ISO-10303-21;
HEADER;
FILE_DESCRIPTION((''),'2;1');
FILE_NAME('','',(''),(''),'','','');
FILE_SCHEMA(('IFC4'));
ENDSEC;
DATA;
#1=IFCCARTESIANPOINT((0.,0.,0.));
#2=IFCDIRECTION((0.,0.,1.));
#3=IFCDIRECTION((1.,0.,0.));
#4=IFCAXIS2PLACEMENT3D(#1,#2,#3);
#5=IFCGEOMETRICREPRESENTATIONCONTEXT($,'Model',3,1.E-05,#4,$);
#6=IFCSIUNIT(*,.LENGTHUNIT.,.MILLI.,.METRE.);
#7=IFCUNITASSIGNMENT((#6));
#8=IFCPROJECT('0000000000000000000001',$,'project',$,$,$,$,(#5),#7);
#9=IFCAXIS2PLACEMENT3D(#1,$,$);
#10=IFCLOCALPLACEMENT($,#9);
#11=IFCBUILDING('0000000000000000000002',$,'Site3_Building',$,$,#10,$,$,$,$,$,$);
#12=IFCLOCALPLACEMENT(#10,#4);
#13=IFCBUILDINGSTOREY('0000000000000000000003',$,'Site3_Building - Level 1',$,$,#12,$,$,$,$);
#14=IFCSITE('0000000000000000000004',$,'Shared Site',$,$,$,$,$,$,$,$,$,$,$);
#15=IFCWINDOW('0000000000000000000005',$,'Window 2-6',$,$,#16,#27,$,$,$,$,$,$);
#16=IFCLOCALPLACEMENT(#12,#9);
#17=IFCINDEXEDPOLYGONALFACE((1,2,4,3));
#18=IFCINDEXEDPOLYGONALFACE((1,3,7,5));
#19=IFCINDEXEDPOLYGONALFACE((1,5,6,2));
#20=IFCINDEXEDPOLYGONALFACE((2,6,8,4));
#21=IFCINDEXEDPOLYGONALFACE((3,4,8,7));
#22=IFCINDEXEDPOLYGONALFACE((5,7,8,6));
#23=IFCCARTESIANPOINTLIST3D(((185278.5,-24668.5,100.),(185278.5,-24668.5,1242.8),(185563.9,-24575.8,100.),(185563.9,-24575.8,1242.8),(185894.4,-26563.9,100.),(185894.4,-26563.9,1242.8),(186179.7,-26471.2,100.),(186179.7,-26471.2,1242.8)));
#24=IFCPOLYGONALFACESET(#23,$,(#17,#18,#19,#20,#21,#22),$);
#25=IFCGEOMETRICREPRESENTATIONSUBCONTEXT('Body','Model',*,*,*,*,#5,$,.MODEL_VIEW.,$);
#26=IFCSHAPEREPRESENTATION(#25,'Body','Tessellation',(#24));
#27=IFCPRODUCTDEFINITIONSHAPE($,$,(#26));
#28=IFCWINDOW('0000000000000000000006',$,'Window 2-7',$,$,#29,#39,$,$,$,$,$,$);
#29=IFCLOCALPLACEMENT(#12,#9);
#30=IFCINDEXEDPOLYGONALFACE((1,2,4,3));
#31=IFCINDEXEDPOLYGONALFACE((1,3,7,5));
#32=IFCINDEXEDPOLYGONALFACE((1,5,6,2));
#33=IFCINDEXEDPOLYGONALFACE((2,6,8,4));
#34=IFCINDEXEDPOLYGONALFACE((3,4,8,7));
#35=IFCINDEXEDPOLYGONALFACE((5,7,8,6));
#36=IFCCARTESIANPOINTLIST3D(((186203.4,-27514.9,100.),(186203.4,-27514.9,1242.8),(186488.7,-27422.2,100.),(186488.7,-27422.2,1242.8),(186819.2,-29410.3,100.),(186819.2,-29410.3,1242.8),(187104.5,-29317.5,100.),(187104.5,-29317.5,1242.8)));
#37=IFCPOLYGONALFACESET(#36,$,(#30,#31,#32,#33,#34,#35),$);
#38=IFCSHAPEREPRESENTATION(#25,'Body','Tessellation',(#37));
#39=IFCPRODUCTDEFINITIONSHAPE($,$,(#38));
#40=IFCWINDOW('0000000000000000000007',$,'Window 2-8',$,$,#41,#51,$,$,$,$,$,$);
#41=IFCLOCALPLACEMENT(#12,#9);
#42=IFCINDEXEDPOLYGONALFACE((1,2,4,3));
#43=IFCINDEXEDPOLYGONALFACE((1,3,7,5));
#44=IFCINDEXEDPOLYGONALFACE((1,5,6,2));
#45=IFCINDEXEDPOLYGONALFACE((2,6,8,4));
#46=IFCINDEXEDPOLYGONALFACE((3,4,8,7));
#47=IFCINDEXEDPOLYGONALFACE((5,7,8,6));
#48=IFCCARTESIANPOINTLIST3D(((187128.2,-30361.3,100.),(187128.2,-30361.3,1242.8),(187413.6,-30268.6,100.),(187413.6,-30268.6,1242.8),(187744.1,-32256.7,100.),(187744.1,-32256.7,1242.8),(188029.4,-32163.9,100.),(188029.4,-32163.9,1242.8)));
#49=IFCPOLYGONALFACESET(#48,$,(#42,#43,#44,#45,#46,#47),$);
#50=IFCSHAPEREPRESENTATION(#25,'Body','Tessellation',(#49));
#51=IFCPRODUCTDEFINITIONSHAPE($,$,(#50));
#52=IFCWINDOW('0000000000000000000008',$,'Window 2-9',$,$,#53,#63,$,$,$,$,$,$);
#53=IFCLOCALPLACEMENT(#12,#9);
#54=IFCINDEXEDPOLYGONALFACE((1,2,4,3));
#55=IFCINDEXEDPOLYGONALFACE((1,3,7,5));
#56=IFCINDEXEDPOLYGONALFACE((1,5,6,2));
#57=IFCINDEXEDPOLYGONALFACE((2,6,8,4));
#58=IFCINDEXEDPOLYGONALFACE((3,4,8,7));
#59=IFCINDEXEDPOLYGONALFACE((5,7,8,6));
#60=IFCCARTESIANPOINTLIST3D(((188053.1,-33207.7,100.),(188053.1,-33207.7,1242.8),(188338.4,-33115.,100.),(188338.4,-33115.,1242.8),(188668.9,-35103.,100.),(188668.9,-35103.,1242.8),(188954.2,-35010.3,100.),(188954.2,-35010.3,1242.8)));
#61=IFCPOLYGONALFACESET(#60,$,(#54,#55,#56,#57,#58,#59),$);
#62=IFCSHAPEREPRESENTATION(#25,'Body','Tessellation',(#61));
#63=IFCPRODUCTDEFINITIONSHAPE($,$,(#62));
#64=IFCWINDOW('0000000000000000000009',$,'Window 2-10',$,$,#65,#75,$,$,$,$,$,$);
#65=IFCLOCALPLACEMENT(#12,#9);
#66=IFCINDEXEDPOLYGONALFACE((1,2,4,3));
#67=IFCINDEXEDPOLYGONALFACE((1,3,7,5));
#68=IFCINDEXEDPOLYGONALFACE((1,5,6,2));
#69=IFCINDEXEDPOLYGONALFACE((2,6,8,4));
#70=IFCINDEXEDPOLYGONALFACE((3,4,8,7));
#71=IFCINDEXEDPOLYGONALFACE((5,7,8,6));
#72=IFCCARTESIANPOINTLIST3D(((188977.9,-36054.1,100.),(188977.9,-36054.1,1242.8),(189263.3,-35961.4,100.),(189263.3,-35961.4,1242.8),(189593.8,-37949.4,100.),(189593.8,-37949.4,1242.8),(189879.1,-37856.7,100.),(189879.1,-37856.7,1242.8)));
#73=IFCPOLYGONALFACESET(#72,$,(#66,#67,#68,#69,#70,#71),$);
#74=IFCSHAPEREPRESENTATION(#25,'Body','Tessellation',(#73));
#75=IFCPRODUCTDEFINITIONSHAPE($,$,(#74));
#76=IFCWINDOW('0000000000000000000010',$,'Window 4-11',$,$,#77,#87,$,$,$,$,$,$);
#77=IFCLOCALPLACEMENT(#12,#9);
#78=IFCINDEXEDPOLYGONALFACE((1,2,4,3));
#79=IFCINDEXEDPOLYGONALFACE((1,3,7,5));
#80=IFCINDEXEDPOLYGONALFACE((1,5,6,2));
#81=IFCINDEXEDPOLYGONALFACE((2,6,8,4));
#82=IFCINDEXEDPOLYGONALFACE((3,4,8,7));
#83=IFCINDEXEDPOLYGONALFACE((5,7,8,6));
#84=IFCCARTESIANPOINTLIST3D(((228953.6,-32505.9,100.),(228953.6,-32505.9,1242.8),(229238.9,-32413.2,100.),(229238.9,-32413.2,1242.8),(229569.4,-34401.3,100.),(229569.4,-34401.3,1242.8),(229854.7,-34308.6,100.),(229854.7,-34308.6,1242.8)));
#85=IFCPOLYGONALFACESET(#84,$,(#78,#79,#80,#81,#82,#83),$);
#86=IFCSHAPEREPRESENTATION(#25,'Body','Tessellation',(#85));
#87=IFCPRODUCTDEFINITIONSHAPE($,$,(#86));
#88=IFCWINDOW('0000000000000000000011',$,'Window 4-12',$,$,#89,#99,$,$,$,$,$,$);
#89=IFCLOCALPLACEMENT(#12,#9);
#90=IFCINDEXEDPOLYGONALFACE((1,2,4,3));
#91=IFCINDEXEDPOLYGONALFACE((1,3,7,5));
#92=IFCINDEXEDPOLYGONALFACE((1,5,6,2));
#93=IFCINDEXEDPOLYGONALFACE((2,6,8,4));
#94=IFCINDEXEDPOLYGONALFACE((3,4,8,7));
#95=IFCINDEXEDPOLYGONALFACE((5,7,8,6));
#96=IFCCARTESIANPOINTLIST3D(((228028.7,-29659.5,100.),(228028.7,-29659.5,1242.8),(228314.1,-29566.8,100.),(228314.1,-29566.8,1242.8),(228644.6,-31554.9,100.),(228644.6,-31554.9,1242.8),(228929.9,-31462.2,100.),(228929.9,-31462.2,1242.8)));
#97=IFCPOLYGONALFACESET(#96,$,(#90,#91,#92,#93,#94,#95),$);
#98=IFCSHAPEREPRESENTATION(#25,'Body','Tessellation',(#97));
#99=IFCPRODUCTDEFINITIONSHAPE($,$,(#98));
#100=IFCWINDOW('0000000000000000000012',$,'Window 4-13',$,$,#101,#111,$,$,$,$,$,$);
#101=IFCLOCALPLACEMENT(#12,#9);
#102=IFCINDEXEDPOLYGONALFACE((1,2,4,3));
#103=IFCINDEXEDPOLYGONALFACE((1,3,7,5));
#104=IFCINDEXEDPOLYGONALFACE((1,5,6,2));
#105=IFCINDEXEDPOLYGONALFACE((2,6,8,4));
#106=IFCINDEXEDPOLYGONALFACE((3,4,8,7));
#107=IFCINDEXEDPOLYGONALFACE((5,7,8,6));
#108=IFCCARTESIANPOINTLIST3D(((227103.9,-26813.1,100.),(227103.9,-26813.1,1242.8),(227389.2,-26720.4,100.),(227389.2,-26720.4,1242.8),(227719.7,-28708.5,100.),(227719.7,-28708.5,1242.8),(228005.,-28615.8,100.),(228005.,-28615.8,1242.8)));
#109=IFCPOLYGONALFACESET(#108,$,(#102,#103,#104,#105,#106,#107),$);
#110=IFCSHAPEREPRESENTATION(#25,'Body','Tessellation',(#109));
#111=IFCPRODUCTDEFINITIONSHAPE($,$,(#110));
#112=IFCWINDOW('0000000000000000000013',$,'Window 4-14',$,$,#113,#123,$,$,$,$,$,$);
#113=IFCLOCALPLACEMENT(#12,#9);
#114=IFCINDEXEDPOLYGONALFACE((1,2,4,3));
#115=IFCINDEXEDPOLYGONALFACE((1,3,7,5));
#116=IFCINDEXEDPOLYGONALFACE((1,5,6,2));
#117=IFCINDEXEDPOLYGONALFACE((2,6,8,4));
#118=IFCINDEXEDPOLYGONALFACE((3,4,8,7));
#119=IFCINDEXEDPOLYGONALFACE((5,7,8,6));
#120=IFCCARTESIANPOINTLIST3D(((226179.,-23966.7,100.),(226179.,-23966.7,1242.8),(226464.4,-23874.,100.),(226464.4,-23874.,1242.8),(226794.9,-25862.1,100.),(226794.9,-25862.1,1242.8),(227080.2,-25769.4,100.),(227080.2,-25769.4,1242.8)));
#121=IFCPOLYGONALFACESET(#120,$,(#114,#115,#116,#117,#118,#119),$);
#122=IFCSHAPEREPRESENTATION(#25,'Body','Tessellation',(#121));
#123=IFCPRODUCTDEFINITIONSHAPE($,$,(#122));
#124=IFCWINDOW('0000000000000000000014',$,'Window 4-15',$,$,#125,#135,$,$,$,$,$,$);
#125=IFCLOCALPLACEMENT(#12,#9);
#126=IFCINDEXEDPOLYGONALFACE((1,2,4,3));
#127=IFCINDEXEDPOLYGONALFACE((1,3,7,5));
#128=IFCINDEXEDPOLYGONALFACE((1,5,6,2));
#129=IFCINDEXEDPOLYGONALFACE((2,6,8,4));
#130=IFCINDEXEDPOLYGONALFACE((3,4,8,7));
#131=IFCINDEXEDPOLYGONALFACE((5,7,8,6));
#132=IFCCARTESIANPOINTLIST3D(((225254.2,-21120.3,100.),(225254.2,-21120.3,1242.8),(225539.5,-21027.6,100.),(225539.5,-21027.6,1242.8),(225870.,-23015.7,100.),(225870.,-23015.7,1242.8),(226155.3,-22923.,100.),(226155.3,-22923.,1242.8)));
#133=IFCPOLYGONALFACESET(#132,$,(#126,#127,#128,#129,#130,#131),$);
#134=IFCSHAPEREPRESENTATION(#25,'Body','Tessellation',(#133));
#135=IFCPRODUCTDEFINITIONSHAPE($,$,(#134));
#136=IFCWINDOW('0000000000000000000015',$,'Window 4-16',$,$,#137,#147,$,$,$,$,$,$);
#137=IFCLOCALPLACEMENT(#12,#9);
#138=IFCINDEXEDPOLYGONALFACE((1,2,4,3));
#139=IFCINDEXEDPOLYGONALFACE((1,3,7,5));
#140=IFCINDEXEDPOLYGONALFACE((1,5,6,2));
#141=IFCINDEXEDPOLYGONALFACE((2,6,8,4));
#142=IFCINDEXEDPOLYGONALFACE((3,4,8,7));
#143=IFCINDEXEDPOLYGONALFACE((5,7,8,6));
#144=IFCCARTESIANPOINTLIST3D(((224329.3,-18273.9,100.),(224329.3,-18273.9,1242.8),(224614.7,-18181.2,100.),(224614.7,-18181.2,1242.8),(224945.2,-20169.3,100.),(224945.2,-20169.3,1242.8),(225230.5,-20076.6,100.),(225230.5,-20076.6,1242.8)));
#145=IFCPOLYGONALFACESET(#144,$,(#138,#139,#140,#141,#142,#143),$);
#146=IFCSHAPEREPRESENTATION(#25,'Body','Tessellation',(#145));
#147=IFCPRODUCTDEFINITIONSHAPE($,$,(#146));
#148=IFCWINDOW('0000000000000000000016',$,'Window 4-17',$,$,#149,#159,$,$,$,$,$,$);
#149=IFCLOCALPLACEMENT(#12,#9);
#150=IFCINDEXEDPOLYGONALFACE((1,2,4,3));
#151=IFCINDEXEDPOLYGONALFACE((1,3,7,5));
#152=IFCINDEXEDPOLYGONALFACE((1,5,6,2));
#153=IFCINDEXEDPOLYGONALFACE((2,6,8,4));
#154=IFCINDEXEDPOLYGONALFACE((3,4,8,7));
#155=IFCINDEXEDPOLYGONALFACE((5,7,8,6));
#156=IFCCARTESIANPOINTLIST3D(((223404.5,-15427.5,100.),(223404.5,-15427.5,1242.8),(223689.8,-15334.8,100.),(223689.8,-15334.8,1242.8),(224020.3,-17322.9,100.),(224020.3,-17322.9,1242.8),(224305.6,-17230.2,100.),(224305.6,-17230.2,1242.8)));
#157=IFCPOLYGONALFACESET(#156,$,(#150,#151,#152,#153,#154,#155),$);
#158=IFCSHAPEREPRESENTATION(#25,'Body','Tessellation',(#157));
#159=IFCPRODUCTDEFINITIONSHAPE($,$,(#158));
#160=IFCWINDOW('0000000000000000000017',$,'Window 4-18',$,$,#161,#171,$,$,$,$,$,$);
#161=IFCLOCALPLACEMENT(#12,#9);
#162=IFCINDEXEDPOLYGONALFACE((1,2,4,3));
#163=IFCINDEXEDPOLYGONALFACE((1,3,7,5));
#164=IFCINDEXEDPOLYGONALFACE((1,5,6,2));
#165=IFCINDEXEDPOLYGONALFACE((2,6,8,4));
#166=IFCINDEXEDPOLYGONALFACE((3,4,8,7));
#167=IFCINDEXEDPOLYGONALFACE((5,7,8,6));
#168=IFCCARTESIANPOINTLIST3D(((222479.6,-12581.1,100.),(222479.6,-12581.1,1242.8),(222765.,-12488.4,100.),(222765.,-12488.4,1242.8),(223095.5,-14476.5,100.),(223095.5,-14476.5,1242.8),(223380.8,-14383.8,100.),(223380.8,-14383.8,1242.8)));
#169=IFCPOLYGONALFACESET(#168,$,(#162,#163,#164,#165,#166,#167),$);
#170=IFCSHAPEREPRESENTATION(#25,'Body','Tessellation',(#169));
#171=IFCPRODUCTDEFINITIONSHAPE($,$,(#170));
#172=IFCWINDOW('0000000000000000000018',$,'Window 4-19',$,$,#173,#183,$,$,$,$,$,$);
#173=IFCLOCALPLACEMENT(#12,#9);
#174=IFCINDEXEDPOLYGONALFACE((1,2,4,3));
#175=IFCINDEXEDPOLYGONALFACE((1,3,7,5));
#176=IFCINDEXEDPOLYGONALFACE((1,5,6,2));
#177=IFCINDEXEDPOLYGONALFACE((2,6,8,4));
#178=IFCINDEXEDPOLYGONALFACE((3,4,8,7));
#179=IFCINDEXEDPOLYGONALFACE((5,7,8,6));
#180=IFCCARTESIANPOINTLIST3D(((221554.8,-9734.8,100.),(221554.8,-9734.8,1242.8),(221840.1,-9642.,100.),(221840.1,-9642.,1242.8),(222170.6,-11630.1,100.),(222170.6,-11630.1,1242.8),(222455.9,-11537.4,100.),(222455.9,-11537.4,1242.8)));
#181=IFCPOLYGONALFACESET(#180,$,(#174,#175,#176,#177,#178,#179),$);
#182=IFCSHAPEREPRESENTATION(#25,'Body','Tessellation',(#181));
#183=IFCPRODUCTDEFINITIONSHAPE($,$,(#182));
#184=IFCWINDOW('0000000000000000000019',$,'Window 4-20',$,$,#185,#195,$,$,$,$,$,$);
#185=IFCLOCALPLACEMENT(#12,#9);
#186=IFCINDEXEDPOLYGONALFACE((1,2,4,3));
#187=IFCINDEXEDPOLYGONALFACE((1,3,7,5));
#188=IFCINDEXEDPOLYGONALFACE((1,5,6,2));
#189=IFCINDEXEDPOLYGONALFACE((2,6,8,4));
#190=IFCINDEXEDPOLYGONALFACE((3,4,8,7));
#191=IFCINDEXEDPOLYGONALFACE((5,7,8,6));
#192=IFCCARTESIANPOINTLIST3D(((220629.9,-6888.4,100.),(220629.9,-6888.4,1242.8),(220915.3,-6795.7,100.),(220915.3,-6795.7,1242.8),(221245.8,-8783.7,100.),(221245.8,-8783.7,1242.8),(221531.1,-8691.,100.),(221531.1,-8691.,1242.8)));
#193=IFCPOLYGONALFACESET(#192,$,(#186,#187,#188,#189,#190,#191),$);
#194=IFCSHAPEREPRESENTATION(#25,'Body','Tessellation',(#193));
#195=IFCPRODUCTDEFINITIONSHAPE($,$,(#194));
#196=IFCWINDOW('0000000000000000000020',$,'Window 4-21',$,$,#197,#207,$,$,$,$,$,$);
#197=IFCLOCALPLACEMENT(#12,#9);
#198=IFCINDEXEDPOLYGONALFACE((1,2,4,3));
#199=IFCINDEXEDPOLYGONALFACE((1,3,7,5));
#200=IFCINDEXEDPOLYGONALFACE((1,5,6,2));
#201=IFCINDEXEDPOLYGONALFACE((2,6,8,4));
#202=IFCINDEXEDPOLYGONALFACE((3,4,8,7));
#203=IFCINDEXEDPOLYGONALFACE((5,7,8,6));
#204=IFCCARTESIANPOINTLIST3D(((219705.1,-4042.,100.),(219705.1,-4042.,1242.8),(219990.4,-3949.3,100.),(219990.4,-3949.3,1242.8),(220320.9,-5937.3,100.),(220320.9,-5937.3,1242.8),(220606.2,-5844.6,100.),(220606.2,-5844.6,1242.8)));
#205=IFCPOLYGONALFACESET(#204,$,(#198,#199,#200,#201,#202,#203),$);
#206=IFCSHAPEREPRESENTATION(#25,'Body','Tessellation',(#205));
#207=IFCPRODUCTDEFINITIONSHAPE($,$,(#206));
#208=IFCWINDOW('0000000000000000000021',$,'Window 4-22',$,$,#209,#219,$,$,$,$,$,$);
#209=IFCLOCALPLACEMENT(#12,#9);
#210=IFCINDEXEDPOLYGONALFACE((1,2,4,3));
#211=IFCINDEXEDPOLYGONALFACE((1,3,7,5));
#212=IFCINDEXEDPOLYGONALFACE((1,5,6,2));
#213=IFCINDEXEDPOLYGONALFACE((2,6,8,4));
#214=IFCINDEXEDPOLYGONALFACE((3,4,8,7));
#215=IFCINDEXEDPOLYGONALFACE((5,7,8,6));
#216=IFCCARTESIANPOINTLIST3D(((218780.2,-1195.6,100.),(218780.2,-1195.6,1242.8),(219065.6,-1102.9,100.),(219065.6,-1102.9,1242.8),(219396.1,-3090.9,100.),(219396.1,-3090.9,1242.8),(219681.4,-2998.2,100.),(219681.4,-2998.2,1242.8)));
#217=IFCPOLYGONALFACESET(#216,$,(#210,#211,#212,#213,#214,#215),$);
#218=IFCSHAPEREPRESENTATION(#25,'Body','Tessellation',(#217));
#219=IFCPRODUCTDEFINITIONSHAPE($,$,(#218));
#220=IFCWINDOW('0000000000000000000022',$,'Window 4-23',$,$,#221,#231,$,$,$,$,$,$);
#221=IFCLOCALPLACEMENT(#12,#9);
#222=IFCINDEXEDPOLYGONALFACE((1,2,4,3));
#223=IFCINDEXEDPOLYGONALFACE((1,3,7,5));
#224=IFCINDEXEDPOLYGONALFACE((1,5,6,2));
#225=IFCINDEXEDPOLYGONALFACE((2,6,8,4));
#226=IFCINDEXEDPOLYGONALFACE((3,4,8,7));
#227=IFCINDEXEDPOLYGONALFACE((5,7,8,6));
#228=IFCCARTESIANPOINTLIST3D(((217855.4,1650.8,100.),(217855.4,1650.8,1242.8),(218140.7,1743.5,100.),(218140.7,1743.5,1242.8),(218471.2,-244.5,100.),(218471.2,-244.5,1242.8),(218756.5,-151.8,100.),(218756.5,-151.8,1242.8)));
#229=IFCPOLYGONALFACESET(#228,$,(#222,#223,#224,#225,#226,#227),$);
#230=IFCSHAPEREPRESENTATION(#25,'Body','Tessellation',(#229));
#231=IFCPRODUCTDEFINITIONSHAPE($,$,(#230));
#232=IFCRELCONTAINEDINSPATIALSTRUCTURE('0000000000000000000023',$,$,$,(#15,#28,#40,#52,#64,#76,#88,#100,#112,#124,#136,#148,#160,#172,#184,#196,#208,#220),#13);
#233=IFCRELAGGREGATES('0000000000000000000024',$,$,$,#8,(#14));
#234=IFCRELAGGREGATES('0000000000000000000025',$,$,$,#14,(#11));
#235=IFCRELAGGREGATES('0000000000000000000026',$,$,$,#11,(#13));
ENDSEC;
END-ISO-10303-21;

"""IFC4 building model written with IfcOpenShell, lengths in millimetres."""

from ifc_helpers import new_model, si_unit, frame, origin, origin_with_axes, place, context, subcontext, project, spatial, indexed_curve, outline, extrude, element, save


model = new_model("IFC4")

# Units and contexts
model_context = context("Model", 3, precision=1e-05, world=origin_with_axes())
body_context = subcontext(model_context, "Body", "Model", "MODEL_VIEW")
ifc_project = project(units=[si_unit("LENGTHUNIT", "METRE", prefix="MILLI")], contexts=[model_context])

# Site, building, storey
site = spatial("IfcSite", under=ifc_project, Name="Shared Site")
building_placement = place(None, origin())
building = spatial("IfcBuilding", under=site, at=building_placement, Name="Site3_Building")
storey_placement = place(building_placement, origin_with_axes())
storey = spatial("IfcBuildingStorey", under=building, at=storey_placement, Name="Site3_Building - Level 1")

# Windows
for number, where, z_axis, x_axis, name in (
    (1, (185278.5, -24668.5, 100.0), (0.0, 0.0, 1.0), (0.309017, -0.951057, 0.0), "Window 2-6"),
    (2, (186203.4, -27514.9, 100.0), (0.0, 0.0, 1.0), (0.309017, -0.951057, 0.0), "Window 2-7"),
    (3, (187128.2, -30361.3, 100.0), (0.0, 0.0, 1.0), (0.309017, -0.951057, 0.0), "Window 2-8"),
    (4, (188053.1, -33207.7, 100.0), (0.0, 0.0, 1.0), (0.309017, -0.951057, 0.0), "Window 2-9"),
    (5, (188977.9, -36054.1, 100.0), (0.0, 0.0, 1.0), (0.309017, -0.951057, 0.0), "Window 2-10"),
    (6, (229854.7, -34308.6, 100.0), (0.0, 0.0, 1.0), (-0.309017, 0.951057, 0.0), "Window 4-11"),
    (7, (228929.9, -31462.2, 100.0), (0.0, 0.0, 1.0), (-0.309017, 0.951057, 0.0), "Window 4-12"),
    (8, (228005.0, -28615.8, 100.0), (0.0, 0.0, 1.0), (-0.309017, 0.951057, 0.0), "Window 4-13"),
    (9, (227080.2, -25769.4, 100.0), (0.0, 0.0, 1.0), (-0.309017, 0.951057, 0.0), "Window 4-14"),
    (10, (226155.3, -22923.0, 100.0), (0.0, 0.0, 1.0), (-0.309017, 0.951057, 0.0), "Window 4-15"),
    (11, (225230.5, -20076.6, 100.0), (0.0, 0.0, 1.0), (-0.309017, 0.951057, 0.0), "Window 4-16"),
    (12, (224305.6, -17230.2, 100.0), (0.0, 0.0, 1.0), (-0.309017, 0.951057, 0.0), "Window 4-17"),
    (13, (223380.8, -14383.8, 100.0), (0.0, 0.0, 1.0), (-0.309017, 0.951057, 0.0), "Window 4-18"),
    (14, (222455.9, -11537.4, 100.0), (0.0, 0.0, 1.0), (-0.309017, 0.951057, 0.0), "Window 4-19"),
    (15, (221531.1, -8691.0, 100.0), (0.0, 0.0, 1.0), (-0.309017, 0.951057, 0.0), "Window 4-20"),
    (16, (220606.2, -5844.6, 100.0), (0.0, 0.0, 1.0), (-0.309017, 0.951057, 0.0), "Window 4-21"),
    (17, (219681.4, -2998.2, 100.0), (0.0, 0.0, 1.0), (-0.309017, 0.951057, 0.0), "Window 4-22"),
    (18, (218756.5, -151.8, 100.0), (0.0, 0.0, 1.0), (-0.309017, 0.951057, 0.0), "Window 4-23"),
):
    element("IfcWindow", number, at=place(storey_placement, frame(where, z_axis=z_axis, x_axis=x_axis)), inside=storey, Name=name, context=body_context, shape_type="SweptSolid", body=[
        extrude(outline(indexed_curve([(0.0, 0.0), (0.0, 300.0), (1992.9, 300.0), (1992.9, 0.0), (0.0, 0.0)], self_intersect=False)), origin_with_axes(), (0.0, 0.0, 1.0), 1142.8),
    ])

save(model, "model.ifc")
